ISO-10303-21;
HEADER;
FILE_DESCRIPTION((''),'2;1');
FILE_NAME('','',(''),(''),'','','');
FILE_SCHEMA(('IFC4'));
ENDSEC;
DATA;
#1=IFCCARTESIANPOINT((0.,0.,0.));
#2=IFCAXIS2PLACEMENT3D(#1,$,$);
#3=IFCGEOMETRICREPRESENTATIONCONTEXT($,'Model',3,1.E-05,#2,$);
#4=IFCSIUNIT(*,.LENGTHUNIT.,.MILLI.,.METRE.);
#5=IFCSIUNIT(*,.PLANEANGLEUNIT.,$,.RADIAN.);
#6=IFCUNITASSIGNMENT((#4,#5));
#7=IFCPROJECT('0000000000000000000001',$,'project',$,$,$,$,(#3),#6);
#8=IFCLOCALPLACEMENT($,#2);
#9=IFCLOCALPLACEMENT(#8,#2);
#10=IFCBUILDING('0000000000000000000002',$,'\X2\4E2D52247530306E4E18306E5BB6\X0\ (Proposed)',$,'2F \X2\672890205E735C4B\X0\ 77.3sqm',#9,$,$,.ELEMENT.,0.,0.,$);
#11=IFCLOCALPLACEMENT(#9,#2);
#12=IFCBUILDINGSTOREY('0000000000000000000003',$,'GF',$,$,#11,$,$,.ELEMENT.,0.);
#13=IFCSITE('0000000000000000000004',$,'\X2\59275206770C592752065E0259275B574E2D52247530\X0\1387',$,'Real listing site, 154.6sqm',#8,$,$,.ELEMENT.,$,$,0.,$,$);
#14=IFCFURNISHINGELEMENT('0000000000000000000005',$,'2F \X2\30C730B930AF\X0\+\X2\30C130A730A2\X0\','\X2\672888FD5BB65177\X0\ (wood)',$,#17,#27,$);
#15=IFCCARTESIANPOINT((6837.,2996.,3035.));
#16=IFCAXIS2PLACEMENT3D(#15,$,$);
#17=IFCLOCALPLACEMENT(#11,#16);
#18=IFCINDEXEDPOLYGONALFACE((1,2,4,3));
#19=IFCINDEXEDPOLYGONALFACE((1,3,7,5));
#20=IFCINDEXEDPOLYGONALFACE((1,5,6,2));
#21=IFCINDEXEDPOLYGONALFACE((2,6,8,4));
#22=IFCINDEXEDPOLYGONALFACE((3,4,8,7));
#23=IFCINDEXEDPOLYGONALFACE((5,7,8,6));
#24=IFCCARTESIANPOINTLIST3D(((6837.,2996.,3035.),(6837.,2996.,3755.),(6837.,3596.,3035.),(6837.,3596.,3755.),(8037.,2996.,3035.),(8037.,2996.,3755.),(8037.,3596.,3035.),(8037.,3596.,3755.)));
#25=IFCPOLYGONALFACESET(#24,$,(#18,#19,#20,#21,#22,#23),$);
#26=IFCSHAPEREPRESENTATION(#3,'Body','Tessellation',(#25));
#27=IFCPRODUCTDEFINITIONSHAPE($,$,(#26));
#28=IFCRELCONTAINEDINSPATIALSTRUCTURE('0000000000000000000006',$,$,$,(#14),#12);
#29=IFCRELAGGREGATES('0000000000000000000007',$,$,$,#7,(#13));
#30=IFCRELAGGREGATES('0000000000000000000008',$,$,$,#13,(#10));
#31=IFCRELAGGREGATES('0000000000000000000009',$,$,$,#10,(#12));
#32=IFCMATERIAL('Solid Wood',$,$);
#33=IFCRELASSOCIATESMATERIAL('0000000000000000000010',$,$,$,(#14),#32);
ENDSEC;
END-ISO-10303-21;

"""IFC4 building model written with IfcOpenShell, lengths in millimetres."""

from ifc_helpers import new_model, si_unit, frame, frame_2d, origin, place, context, project, spatial, rectangle, extrude, material, element, save


model = new_model("IFC4")

# Units and contexts
model_context = context("Model", 3, precision=1e-05, world=origin())
ifc_project = project(units=[si_unit("LENGTHUNIT", "METRE", prefix="MILLI"), si_unit("PLANEANGLEUNIT", "RADIAN")], contexts=[model_context])

# Site, building, storey
site_placement = place(None, origin())
site = spatial("IfcSite", under=ifc_project, at=site_placement, Name="大分県大分市大字中判田1387", ObjectType="Real listing site, 154.6sqm", CompositionType="ELEMENT", RefElevation=0.0)
building_placement = place(site_placement, origin())
building = spatial("IfcBuilding", under=site, at=building_placement, Name="中判田の丘の家 (Proposed)", ObjectType="2F 木造平屋 77.3sqm", CompositionType="ELEMENT", ElevationOfRefHeight=0.0, ElevationOfTerrain=0.0)
storey_placement = place(building_placement, origin())
storey = spatial("IfcBuildingStorey", under=building, at=storey_placement, Name="GF", CompositionType="ELEMENT", Elevation=0.0)

# Shared definitions
ifc_material_1 = material(Name="Solid Wood")

# Furnishing element
furnishing_1_placement = place(storey_placement, frame((6837.0, 2996.0, 3035.0)))
element("IfcFurnishingElement", 1, at=furnishing_1_placement, inside=storey, material=ifc_material_1, Name="2F デスク+チェア", Description="木製家具 (wood)", context=model_context, shape_type="SweptSolid", body=[
    extrude(rectangle(XDim=1200.0, YDim=600.0, at=frame_2d((600.0, 300.0))), frame((6837.0, 2996.0, 3035.0)), (0.0, 0.0, 1.0), 720.0),
])

save(model, "model.ifc")
